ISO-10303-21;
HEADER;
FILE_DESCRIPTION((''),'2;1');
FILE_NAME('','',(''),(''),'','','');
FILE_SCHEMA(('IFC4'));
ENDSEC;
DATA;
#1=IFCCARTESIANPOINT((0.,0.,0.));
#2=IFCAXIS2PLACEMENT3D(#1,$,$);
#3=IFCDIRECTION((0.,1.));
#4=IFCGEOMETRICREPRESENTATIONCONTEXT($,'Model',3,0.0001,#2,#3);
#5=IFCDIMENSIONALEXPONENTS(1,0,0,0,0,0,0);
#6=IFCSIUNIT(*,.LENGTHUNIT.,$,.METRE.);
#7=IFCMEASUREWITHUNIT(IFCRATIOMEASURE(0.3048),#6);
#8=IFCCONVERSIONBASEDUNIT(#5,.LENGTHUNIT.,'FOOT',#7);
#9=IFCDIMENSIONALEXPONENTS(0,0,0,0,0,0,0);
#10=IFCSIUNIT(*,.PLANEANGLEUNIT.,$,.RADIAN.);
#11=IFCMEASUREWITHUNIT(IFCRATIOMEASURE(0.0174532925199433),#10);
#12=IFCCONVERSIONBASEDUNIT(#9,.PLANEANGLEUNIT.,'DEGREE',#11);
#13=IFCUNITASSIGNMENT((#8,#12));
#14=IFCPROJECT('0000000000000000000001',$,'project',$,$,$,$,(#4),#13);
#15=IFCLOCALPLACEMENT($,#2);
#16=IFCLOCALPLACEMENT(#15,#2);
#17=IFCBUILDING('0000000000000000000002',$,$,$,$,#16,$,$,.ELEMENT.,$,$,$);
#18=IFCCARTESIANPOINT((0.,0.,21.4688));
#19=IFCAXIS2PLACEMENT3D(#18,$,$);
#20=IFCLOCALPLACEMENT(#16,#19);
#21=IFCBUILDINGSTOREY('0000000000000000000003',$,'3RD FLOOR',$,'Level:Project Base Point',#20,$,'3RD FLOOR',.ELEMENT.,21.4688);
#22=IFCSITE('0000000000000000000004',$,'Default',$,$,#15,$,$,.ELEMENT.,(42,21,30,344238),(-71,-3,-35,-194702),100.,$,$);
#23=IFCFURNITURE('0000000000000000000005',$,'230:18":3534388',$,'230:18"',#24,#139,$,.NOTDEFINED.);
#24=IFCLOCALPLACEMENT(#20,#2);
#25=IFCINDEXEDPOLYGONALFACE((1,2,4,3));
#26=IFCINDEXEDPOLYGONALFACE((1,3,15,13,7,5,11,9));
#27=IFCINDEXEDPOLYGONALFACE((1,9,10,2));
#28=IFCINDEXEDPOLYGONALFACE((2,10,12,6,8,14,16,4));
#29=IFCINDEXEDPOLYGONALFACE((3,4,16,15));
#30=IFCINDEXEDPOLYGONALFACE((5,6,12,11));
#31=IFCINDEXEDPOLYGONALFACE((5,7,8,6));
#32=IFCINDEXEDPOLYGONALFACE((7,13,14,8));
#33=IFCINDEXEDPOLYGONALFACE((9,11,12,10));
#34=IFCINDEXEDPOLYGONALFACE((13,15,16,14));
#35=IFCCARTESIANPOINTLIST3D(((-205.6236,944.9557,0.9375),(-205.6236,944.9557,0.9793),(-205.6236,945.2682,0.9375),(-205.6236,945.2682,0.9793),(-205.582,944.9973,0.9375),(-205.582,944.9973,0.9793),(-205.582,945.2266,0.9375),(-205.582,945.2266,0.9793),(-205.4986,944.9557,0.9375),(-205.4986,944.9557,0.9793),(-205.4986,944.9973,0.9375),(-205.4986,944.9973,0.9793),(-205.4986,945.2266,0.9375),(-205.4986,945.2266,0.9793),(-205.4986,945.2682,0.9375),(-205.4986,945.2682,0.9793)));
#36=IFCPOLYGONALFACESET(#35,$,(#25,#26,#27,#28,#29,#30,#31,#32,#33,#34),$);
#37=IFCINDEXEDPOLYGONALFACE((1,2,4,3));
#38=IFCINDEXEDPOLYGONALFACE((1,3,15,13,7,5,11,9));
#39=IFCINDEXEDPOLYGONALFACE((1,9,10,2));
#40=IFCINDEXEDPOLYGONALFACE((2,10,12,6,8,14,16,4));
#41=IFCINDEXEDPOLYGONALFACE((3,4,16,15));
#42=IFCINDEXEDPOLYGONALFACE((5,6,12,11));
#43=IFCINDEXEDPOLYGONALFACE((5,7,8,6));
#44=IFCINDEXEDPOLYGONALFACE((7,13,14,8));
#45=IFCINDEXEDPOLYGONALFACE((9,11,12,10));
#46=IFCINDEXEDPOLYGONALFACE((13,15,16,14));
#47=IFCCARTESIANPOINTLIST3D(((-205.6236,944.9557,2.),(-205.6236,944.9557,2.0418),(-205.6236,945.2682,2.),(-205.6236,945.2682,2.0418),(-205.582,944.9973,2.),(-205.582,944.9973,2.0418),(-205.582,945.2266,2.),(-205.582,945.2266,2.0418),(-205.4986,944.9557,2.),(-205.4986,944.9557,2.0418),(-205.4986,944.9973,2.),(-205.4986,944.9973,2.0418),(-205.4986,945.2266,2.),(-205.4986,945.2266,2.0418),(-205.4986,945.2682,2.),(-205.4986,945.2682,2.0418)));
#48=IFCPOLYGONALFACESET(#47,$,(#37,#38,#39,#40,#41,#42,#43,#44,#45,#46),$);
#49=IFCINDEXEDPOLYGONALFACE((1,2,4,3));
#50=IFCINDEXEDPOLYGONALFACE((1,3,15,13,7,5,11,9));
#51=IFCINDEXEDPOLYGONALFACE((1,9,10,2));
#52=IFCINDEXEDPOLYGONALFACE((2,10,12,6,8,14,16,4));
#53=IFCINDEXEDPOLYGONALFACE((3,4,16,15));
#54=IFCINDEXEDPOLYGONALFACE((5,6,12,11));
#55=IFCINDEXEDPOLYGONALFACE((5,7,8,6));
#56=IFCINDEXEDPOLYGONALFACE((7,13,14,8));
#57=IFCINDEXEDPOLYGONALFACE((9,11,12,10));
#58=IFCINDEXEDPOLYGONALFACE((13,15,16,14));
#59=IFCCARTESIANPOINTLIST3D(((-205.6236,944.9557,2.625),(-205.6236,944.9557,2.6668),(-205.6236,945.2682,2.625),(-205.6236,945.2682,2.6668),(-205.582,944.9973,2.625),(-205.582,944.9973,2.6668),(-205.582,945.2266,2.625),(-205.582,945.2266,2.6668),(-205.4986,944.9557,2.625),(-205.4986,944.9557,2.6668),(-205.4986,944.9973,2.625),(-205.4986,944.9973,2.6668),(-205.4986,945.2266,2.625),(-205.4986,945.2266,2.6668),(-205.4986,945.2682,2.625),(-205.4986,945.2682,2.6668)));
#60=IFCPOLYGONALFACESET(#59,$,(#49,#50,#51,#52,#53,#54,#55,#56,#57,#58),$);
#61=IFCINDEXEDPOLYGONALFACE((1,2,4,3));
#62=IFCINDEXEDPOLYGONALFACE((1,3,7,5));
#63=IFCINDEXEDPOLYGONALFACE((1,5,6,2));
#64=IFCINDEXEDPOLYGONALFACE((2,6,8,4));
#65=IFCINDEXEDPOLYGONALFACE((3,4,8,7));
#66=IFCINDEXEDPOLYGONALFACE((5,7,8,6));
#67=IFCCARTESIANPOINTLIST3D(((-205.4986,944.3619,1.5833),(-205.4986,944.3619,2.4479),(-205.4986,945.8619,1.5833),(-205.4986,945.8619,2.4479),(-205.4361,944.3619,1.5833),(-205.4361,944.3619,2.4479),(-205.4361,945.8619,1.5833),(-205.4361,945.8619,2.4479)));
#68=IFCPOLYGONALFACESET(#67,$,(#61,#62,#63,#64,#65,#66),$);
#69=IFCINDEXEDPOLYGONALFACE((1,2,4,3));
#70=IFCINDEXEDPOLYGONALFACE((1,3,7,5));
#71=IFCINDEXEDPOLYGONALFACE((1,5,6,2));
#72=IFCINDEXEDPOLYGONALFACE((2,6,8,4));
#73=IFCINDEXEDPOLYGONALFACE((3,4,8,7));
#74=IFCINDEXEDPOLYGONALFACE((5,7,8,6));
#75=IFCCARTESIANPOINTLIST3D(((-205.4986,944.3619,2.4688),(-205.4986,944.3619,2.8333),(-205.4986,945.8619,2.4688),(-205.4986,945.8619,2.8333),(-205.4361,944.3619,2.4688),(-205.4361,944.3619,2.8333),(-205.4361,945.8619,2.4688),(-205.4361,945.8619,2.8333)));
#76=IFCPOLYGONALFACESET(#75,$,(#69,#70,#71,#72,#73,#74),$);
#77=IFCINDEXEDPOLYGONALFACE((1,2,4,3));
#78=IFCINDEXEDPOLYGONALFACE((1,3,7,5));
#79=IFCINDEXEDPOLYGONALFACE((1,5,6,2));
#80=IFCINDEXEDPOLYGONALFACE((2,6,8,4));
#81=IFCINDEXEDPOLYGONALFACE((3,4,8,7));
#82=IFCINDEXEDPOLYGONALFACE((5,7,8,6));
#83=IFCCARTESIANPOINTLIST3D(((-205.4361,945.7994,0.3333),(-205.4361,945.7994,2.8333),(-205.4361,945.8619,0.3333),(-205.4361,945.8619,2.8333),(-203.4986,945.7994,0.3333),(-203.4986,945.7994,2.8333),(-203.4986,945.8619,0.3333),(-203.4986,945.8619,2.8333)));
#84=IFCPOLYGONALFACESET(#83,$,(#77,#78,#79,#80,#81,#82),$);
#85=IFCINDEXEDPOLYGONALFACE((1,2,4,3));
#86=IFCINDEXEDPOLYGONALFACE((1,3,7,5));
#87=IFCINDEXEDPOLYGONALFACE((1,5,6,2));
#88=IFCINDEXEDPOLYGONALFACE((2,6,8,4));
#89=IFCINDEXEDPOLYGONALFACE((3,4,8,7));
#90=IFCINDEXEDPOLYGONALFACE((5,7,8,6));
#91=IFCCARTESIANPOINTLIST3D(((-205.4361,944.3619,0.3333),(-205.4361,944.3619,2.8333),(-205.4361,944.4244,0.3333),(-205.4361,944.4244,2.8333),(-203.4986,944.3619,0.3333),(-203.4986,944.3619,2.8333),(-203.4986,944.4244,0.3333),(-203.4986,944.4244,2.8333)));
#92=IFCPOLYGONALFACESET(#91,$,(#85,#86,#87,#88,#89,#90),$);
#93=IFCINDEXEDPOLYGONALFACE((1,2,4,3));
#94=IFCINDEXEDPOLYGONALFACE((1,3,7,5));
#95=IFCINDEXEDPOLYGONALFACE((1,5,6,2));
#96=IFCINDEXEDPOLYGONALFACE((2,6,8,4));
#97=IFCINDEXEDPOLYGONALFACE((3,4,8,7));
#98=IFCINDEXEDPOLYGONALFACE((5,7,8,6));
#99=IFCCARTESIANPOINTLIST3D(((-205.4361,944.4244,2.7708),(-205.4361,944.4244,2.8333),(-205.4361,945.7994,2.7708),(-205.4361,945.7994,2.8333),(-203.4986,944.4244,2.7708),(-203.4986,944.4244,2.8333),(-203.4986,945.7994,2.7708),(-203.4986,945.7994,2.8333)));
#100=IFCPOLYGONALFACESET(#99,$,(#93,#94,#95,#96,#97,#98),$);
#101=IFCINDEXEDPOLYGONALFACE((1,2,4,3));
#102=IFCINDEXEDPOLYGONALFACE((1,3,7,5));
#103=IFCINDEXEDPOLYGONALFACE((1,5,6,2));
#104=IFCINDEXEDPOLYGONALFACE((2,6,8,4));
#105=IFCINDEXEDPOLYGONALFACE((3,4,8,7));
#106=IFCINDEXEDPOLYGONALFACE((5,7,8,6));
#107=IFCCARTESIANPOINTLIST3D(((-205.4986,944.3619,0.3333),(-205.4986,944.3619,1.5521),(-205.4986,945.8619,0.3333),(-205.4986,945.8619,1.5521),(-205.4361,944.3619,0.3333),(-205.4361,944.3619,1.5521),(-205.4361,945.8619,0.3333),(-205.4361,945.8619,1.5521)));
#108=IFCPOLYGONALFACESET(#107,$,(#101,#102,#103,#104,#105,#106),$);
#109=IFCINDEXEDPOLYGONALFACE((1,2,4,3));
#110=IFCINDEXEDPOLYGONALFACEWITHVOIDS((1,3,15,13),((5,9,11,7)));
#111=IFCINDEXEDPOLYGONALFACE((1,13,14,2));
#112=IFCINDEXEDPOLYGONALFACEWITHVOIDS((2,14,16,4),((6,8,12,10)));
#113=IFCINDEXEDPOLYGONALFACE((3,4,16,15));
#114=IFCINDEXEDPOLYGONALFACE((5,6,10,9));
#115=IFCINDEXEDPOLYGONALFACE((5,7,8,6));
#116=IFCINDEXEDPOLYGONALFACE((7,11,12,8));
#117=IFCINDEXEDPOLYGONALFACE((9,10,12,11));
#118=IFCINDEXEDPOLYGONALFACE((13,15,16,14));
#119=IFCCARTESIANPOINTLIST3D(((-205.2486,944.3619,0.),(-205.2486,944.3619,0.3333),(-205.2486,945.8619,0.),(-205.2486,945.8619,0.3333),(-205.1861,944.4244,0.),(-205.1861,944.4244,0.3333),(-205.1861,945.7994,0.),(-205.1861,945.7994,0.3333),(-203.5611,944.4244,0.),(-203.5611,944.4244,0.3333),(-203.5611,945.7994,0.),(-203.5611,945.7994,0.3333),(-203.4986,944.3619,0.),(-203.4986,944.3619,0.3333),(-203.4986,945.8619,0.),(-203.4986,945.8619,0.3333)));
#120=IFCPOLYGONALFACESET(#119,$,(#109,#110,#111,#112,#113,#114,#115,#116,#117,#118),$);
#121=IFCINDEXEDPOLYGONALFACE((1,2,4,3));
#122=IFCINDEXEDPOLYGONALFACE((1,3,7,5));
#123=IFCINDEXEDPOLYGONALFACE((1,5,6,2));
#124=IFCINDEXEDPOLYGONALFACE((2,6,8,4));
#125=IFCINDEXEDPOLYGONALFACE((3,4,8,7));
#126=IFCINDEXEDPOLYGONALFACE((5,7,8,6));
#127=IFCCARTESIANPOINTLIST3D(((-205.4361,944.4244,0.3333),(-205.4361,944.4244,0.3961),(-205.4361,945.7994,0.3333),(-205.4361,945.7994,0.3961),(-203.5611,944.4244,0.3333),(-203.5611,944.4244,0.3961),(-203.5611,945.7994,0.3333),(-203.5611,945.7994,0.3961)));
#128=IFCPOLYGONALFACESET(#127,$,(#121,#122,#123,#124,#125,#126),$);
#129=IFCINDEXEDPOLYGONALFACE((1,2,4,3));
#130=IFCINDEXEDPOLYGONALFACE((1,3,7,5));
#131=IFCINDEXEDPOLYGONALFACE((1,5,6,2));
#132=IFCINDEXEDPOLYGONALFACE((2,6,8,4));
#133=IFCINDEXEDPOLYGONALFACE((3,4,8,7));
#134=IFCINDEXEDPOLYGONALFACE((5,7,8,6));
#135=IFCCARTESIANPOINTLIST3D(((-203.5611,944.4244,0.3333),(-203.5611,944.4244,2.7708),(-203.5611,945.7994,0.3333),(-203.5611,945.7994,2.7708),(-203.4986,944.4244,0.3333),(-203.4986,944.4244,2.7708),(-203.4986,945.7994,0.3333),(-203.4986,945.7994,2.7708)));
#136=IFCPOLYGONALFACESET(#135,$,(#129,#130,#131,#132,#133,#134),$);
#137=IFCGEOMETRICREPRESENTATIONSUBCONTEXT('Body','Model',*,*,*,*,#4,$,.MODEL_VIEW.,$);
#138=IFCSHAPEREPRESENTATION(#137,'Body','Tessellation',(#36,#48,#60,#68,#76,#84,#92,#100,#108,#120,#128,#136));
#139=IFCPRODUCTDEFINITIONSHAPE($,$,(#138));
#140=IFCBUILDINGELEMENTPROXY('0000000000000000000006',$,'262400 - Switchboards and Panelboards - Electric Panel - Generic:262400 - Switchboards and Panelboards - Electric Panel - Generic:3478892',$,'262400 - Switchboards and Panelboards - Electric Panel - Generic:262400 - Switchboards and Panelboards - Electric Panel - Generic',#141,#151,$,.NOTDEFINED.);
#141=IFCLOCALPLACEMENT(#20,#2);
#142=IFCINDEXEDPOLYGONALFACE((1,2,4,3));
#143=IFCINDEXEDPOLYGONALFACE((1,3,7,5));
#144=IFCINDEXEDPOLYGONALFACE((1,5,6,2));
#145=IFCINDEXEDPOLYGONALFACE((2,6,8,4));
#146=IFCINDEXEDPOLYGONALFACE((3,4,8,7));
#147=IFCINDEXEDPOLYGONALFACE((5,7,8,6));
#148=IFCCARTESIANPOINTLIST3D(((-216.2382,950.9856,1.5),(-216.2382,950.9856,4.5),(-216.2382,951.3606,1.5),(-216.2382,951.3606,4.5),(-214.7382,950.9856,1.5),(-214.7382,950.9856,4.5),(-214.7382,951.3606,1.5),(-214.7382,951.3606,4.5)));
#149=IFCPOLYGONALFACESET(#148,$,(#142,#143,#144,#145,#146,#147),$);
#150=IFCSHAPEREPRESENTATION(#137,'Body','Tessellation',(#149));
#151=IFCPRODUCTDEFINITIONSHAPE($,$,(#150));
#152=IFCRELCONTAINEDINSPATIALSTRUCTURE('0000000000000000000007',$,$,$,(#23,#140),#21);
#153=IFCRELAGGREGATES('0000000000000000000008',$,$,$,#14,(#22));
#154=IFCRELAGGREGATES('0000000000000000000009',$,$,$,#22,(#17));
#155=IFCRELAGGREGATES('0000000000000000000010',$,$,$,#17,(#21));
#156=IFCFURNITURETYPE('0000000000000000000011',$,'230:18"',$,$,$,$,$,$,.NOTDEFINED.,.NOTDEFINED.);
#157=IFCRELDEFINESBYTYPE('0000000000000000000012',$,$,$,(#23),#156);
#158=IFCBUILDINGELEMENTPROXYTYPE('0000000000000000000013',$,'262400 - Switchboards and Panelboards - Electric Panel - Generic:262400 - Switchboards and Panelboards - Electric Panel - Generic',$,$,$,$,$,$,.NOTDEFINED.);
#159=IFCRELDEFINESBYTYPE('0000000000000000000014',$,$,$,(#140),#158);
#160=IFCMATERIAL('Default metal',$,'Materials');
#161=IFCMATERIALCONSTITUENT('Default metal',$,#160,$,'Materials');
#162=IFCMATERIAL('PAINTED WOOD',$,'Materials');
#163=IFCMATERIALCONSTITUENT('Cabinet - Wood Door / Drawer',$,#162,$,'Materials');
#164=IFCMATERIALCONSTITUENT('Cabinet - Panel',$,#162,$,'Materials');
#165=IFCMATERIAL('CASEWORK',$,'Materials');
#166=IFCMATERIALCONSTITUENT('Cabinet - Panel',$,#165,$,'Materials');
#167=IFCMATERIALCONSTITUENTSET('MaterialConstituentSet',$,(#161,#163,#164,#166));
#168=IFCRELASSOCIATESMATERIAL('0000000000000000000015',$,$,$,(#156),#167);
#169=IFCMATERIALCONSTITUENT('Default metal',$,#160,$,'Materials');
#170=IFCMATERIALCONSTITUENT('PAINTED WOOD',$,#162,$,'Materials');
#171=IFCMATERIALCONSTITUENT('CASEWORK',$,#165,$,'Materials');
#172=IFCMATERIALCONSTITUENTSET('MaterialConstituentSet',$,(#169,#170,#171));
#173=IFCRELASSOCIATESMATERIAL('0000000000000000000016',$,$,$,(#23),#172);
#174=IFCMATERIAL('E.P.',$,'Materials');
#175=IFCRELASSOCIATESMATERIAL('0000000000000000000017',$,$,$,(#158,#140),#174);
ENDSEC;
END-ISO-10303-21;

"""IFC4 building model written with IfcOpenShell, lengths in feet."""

from ifc_helpers import new_model, entity, si_unit, converted_unit, direction, frame, frame_2d, origin, origin_2d_with_axis, place, context, subcontext, project, spatial, polyline, rectangle, outline, extrude, source, transform, mapped, material, constituent, constituent_set, type_object, type_shapes, element, save


model = new_model("IFC4")

# Units and contexts
model_context = context("Model", 3, precision=0.0001, world=origin(), true_north=direction((0.0, 1.0)))
body_context = subcontext(model_context, "Body", "Model", "MODEL_VIEW")
ifc_project = project(units=[converted_unit("LENGTHUNIT", "FOOT", entity("IfcRatioMeasure", 0.3048), si_unit("LENGTHUNIT", "METRE"), dimensions=[1, 0, 0, 0, 0, 0, 0]), converted_unit("PLANEANGLEUNIT", "DEGREE", entity("IfcRatioMeasure", 0.0174532925199433), si_unit("PLANEANGLEUNIT", "RADIAN"), dimensions=[0, 0, 0, 0, 0, 0, 0])], contexts=[model_context])

# Site, building, storey
site_placement = place(None, origin())
site = spatial("IfcSite", under=ifc_project, at=site_placement, Name="Default", CompositionType="ELEMENT", RefLatitude=(42, 21, 30, 344238), RefLongitude=(-71, -3, -35, -194702), RefElevation=100.0)
building_placement = place(site_placement, origin())
building = spatial("IfcBuilding", under=site, at=building_placement, CompositionType="ELEMENT")
storey_placement = place(building_placement, frame((0.0, 0.0, 21.4688)))
storey = spatial("IfcBuildingStorey", under=building, at=storey_placement, Name="3RD FLOOR", ObjectType="Level:Project Base Point", LongName="3RD FLOOR", CompositionType="ELEMENT", Elevation=21.4688)

# Furniture
ifc_material_1 = material(Name="CASEWORK", Category="Materials")
ifc_material_2 = material(Name="PAINTED WOOD", Category="Materials")
ifc_material_3 = material(Name="Default metal", Category="Materials")
ifc_constituent_1 = constituent(ifc_material_3, Name="Default metal", Category="Materials")
ifc_constituent_2 = constituent(ifc_material_2, Name="PAINTED WOOD", Category="Materials")
ifc_constituent_3 = constituent(ifc_material_1, Name="CASEWORK", Category="Materials")
ifc_constituent_set_1 = constituent_set(constituents=[ifc_constituent_1, ifc_constituent_2, ifc_constituent_3], Name="MaterialConstituentSet")
ifc_constituent_4 = constituent(ifc_material_3, Name="Default metal", Category="Materials")
ifc_constituent_5 = constituent(ifc_material_2, Name="Cabinet - Wood Door / Drawer", Category="Materials")
ifc_constituent_6 = constituent(ifc_material_2, Name="Cabinet - Panel", Category="Materials")
ifc_constituent_7 = constituent(ifc_material_1, Name="Cabinet - Panel", Category="Materials")
ifc_constituent_set_2 = constituent_set(constituents=[ifc_constituent_4, ifc_constituent_5, ifc_constituent_6, ifc_constituent_7], Name="MaterialConstituentSet")
furniture_type_1 = type_object("IfcFurnitureType", Name="230:18\"", AssemblyPlace="NOTDEFINED", PredefinedType="NOTDEFINED", material=ifc_constituent_set_2)
shared_shape_1 = source(origin(), body_context, "Body", "SweptSolid", [
    extrude(outline(polyline([(-0.0521, -0.1562), (0.0729, -0.1562), (0.0729, 0.1562), (-0.0521, 0.1562), (-0.0521, 0.1146), (0.0313, 0.1146), (0.0313, -0.1146), (-0.0521, -0.1146), (-0.0521, -0.1562)])), frame((0.0615, -2.0521, 0.9375), z_axis=(0.0, 0.0, 1.0), x_axis=(0.0, -1.0, 0.0)), (0.0, 0.0, 1.0), 0.0418),
    extrude(outline(polyline([(-0.0521, -0.1562), (0.0729, -0.1562), (0.0729, 0.1562), (-0.0521, 0.1562), (-0.0521, 0.1146), (0.0313, 0.1146), (0.0313, -0.1146), (-0.0521, -0.1146), (-0.0521, -0.1562)])), frame((0.0615, -2.0521, 2.0), z_axis=(0.0, 0.0, 1.0), x_axis=(0.0, -1.0, 0.0)), (0.0, 0.0, 1.0), 0.0418),
    extrude(outline(polyline([(-0.0521, -0.1562), (0.0729, -0.1562), (0.0729, 0.1562), (-0.0521, 0.1562), (-0.0521, 0.1146), (0.0313, 0.1146), (0.0313, -0.1146), (-0.0521, -0.1146), (-0.0521, -0.1562)])), frame((0.0615, -2.0521, 2.625), z_axis=(0.0, 0.0, 1.0), x_axis=(0.0, -1.0, 0.0)), (0.0, 0.0, 1.0), 0.0418),
    extrude(rectangle(XDim=0.0625, YDim=1.5, at=frame_2d((0.0, 0.0), x_axis=(1.0, 0.0))), frame((0.0615, -1.9688, 1.5833), z_axis=(0.0, 0.0, 1.0), x_axis=(0.0, 1.0, 0.0)), (0.0, 0.0, 1.0), 0.8646),
    extrude(rectangle(XDim=0.0625, YDim=1.5, at=frame_2d((0.0, 0.0), x_axis=(1.0, 0.0))), frame((0.0615, -1.9688, 2.4688), z_axis=(0.0, 0.0, 1.0), x_axis=(0.0, 1.0, 0.0)), (0.0, 0.0, 1.0), 0.3646),
    extrude(rectangle(XDim=0.0625, YDim=1.9375, at=frame_2d((0.0, 0.0), x_axis=(1.0, 0.0))), frame((-0.6573, -0.9687, 0.3333)), (0.0, 0.0, 1.0), 2.5),
    extrude(rectangle(XDim=0.0625, YDim=1.9375, at=frame_2d((0.0, 0.0), x_axis=(1.0, 0.0))), frame((0.7802, -0.9687, 0.3333)), (0.0, 0.0, 1.0), 2.5),
    extrude(rectangle(XDim=1.375, YDim=1.9375, at=origin_2d_with_axis()), frame((0.0615, -0.9687, 2.7708), z_axis=(0.0, 0.0, 1.0), x_axis=(-1.0, 0.0, 0.0)), (0.0, 0.0, 1.0), 0.0625),
    extrude(rectangle(XDim=0.0625, YDim=1.5, at=frame_2d((0.0, 0.0), x_axis=(1.0, 0.0))), frame((0.0615, -1.9688, 0.3333), z_axis=(0.0, 0.0, 1.0), x_axis=(0.0, 1.0, 0.0)), (0.0, 0.0, 1.0), 1.2187),
    extrude(outline(polyline([(-0.75, -0.875), (0.75, -0.875), (0.75, 0.875), (-0.75, 0.875), (-0.75, -0.875)]), holes=[polyline([(-0.6875, -0.8125), (-0.6875, 0.8125), (0.6875, 0.8125), (0.6875, -0.8125), (-0.6875, -0.8125)])]), frame((0.0615, -0.875, 0.0)), (0.0, 0.0, 1.0), 0.3333),
    extrude(rectangle(XDim=1.375, YDim=1.875, at=frame_2d((0.0, 0.0), x_axis=(1.0, 0.0))), frame((0.0615, -1.0, 0.3333), z_axis=(0.0, 0.0, 1.0), x_axis=(-1.0, 0.0, 0.0)), (0.0, 0.0, 1.0), 0.0627),
    extrude(rectangle(XDim=0.0625, YDim=1.375, at=origin_2d_with_axis()), frame((0.0615, -0.0312, 0.3333), z_axis=(0.0, 0.0, 1.0), x_axis=(0.0, 1.0, 0.0)), (0.0, 0.0, 1.0), 2.4375),
])
type_shapes(furniture_type_1, [shared_shape_1])
furniture_1_placement = place(storey_placement, frame((-203.4986, 945.1734, 0.0), z_axis=(0.0, 0.0, 1.0), x_axis=(0.0, -1.0, 0.0)))
element("IfcFurniture", 1, at=furniture_1_placement, inside=storey, type_object=furniture_type_1, material=ifc_constituent_set_1, Name="230:18\":3534388", ObjectType="230:18\"", PredefinedType="NOTDEFINED", context=body_context, shape_type="MappedRepresentation", body=[
    mapped(shared_shape_1, transform((0.0, 0.0, 0.0), scale=1.0)),
])

# Building element proxy
ifc_material_4 = material(Name="E.P.", Category="Materials")
building_element_proxy_type_1 = type_object("IfcBuildingElementProxyType", Name="262400 - Switchboards and Panelboards - Electric Panel - Generic:262400 - Switchboards and Panelboards - Electric Panel - Generic", PredefinedType="NOTDEFINED", material=ifc_material_4)
shared_shape_2 = source(origin(), body_context, "Body", "SweptSolid", [
    extrude(rectangle(XDim=1.5, YDim=0.375, at=origin_2d_with_axis()), frame((0.75, 0.1875, 0.0), z_axis=(0.0, 0.0, 1.0), x_axis=(-1.0, 0.0, 0.0)), (0.0, 0.0, 1.0), 3.0),
])
type_shapes(building_element_proxy_type_1, [shared_shape_2])
proxy_1_placement = place(storey_placement, frame((-214.7382, 951.3606, 1.5), z_axis=(0.0, 0.0, 1.0), x_axis=(-1.0, 0.0, 0.0)))
element("IfcBuildingElementProxy", 2, at=proxy_1_placement, inside=storey, type_object=building_element_proxy_type_1, material=ifc_material_4, Name="262400 - Switchboards and Panelboards - Electric Panel - Generic:262400 - Switchboards and Panelboards - Electric Panel - Generic:3478892", ObjectType="262400 - Switchboards and Panelboards - Electric Panel - Generic:262400 - Switchboards and Panelboards - Electric Panel - Generic", PredefinedType="NOTDEFINED", context=body_context, shape_type="MappedRepresentation", body=[
    mapped(shared_shape_2, transform((0.0, 0.0, 0.0), scale=1.0)),
])

save(model, "model.ifc")
